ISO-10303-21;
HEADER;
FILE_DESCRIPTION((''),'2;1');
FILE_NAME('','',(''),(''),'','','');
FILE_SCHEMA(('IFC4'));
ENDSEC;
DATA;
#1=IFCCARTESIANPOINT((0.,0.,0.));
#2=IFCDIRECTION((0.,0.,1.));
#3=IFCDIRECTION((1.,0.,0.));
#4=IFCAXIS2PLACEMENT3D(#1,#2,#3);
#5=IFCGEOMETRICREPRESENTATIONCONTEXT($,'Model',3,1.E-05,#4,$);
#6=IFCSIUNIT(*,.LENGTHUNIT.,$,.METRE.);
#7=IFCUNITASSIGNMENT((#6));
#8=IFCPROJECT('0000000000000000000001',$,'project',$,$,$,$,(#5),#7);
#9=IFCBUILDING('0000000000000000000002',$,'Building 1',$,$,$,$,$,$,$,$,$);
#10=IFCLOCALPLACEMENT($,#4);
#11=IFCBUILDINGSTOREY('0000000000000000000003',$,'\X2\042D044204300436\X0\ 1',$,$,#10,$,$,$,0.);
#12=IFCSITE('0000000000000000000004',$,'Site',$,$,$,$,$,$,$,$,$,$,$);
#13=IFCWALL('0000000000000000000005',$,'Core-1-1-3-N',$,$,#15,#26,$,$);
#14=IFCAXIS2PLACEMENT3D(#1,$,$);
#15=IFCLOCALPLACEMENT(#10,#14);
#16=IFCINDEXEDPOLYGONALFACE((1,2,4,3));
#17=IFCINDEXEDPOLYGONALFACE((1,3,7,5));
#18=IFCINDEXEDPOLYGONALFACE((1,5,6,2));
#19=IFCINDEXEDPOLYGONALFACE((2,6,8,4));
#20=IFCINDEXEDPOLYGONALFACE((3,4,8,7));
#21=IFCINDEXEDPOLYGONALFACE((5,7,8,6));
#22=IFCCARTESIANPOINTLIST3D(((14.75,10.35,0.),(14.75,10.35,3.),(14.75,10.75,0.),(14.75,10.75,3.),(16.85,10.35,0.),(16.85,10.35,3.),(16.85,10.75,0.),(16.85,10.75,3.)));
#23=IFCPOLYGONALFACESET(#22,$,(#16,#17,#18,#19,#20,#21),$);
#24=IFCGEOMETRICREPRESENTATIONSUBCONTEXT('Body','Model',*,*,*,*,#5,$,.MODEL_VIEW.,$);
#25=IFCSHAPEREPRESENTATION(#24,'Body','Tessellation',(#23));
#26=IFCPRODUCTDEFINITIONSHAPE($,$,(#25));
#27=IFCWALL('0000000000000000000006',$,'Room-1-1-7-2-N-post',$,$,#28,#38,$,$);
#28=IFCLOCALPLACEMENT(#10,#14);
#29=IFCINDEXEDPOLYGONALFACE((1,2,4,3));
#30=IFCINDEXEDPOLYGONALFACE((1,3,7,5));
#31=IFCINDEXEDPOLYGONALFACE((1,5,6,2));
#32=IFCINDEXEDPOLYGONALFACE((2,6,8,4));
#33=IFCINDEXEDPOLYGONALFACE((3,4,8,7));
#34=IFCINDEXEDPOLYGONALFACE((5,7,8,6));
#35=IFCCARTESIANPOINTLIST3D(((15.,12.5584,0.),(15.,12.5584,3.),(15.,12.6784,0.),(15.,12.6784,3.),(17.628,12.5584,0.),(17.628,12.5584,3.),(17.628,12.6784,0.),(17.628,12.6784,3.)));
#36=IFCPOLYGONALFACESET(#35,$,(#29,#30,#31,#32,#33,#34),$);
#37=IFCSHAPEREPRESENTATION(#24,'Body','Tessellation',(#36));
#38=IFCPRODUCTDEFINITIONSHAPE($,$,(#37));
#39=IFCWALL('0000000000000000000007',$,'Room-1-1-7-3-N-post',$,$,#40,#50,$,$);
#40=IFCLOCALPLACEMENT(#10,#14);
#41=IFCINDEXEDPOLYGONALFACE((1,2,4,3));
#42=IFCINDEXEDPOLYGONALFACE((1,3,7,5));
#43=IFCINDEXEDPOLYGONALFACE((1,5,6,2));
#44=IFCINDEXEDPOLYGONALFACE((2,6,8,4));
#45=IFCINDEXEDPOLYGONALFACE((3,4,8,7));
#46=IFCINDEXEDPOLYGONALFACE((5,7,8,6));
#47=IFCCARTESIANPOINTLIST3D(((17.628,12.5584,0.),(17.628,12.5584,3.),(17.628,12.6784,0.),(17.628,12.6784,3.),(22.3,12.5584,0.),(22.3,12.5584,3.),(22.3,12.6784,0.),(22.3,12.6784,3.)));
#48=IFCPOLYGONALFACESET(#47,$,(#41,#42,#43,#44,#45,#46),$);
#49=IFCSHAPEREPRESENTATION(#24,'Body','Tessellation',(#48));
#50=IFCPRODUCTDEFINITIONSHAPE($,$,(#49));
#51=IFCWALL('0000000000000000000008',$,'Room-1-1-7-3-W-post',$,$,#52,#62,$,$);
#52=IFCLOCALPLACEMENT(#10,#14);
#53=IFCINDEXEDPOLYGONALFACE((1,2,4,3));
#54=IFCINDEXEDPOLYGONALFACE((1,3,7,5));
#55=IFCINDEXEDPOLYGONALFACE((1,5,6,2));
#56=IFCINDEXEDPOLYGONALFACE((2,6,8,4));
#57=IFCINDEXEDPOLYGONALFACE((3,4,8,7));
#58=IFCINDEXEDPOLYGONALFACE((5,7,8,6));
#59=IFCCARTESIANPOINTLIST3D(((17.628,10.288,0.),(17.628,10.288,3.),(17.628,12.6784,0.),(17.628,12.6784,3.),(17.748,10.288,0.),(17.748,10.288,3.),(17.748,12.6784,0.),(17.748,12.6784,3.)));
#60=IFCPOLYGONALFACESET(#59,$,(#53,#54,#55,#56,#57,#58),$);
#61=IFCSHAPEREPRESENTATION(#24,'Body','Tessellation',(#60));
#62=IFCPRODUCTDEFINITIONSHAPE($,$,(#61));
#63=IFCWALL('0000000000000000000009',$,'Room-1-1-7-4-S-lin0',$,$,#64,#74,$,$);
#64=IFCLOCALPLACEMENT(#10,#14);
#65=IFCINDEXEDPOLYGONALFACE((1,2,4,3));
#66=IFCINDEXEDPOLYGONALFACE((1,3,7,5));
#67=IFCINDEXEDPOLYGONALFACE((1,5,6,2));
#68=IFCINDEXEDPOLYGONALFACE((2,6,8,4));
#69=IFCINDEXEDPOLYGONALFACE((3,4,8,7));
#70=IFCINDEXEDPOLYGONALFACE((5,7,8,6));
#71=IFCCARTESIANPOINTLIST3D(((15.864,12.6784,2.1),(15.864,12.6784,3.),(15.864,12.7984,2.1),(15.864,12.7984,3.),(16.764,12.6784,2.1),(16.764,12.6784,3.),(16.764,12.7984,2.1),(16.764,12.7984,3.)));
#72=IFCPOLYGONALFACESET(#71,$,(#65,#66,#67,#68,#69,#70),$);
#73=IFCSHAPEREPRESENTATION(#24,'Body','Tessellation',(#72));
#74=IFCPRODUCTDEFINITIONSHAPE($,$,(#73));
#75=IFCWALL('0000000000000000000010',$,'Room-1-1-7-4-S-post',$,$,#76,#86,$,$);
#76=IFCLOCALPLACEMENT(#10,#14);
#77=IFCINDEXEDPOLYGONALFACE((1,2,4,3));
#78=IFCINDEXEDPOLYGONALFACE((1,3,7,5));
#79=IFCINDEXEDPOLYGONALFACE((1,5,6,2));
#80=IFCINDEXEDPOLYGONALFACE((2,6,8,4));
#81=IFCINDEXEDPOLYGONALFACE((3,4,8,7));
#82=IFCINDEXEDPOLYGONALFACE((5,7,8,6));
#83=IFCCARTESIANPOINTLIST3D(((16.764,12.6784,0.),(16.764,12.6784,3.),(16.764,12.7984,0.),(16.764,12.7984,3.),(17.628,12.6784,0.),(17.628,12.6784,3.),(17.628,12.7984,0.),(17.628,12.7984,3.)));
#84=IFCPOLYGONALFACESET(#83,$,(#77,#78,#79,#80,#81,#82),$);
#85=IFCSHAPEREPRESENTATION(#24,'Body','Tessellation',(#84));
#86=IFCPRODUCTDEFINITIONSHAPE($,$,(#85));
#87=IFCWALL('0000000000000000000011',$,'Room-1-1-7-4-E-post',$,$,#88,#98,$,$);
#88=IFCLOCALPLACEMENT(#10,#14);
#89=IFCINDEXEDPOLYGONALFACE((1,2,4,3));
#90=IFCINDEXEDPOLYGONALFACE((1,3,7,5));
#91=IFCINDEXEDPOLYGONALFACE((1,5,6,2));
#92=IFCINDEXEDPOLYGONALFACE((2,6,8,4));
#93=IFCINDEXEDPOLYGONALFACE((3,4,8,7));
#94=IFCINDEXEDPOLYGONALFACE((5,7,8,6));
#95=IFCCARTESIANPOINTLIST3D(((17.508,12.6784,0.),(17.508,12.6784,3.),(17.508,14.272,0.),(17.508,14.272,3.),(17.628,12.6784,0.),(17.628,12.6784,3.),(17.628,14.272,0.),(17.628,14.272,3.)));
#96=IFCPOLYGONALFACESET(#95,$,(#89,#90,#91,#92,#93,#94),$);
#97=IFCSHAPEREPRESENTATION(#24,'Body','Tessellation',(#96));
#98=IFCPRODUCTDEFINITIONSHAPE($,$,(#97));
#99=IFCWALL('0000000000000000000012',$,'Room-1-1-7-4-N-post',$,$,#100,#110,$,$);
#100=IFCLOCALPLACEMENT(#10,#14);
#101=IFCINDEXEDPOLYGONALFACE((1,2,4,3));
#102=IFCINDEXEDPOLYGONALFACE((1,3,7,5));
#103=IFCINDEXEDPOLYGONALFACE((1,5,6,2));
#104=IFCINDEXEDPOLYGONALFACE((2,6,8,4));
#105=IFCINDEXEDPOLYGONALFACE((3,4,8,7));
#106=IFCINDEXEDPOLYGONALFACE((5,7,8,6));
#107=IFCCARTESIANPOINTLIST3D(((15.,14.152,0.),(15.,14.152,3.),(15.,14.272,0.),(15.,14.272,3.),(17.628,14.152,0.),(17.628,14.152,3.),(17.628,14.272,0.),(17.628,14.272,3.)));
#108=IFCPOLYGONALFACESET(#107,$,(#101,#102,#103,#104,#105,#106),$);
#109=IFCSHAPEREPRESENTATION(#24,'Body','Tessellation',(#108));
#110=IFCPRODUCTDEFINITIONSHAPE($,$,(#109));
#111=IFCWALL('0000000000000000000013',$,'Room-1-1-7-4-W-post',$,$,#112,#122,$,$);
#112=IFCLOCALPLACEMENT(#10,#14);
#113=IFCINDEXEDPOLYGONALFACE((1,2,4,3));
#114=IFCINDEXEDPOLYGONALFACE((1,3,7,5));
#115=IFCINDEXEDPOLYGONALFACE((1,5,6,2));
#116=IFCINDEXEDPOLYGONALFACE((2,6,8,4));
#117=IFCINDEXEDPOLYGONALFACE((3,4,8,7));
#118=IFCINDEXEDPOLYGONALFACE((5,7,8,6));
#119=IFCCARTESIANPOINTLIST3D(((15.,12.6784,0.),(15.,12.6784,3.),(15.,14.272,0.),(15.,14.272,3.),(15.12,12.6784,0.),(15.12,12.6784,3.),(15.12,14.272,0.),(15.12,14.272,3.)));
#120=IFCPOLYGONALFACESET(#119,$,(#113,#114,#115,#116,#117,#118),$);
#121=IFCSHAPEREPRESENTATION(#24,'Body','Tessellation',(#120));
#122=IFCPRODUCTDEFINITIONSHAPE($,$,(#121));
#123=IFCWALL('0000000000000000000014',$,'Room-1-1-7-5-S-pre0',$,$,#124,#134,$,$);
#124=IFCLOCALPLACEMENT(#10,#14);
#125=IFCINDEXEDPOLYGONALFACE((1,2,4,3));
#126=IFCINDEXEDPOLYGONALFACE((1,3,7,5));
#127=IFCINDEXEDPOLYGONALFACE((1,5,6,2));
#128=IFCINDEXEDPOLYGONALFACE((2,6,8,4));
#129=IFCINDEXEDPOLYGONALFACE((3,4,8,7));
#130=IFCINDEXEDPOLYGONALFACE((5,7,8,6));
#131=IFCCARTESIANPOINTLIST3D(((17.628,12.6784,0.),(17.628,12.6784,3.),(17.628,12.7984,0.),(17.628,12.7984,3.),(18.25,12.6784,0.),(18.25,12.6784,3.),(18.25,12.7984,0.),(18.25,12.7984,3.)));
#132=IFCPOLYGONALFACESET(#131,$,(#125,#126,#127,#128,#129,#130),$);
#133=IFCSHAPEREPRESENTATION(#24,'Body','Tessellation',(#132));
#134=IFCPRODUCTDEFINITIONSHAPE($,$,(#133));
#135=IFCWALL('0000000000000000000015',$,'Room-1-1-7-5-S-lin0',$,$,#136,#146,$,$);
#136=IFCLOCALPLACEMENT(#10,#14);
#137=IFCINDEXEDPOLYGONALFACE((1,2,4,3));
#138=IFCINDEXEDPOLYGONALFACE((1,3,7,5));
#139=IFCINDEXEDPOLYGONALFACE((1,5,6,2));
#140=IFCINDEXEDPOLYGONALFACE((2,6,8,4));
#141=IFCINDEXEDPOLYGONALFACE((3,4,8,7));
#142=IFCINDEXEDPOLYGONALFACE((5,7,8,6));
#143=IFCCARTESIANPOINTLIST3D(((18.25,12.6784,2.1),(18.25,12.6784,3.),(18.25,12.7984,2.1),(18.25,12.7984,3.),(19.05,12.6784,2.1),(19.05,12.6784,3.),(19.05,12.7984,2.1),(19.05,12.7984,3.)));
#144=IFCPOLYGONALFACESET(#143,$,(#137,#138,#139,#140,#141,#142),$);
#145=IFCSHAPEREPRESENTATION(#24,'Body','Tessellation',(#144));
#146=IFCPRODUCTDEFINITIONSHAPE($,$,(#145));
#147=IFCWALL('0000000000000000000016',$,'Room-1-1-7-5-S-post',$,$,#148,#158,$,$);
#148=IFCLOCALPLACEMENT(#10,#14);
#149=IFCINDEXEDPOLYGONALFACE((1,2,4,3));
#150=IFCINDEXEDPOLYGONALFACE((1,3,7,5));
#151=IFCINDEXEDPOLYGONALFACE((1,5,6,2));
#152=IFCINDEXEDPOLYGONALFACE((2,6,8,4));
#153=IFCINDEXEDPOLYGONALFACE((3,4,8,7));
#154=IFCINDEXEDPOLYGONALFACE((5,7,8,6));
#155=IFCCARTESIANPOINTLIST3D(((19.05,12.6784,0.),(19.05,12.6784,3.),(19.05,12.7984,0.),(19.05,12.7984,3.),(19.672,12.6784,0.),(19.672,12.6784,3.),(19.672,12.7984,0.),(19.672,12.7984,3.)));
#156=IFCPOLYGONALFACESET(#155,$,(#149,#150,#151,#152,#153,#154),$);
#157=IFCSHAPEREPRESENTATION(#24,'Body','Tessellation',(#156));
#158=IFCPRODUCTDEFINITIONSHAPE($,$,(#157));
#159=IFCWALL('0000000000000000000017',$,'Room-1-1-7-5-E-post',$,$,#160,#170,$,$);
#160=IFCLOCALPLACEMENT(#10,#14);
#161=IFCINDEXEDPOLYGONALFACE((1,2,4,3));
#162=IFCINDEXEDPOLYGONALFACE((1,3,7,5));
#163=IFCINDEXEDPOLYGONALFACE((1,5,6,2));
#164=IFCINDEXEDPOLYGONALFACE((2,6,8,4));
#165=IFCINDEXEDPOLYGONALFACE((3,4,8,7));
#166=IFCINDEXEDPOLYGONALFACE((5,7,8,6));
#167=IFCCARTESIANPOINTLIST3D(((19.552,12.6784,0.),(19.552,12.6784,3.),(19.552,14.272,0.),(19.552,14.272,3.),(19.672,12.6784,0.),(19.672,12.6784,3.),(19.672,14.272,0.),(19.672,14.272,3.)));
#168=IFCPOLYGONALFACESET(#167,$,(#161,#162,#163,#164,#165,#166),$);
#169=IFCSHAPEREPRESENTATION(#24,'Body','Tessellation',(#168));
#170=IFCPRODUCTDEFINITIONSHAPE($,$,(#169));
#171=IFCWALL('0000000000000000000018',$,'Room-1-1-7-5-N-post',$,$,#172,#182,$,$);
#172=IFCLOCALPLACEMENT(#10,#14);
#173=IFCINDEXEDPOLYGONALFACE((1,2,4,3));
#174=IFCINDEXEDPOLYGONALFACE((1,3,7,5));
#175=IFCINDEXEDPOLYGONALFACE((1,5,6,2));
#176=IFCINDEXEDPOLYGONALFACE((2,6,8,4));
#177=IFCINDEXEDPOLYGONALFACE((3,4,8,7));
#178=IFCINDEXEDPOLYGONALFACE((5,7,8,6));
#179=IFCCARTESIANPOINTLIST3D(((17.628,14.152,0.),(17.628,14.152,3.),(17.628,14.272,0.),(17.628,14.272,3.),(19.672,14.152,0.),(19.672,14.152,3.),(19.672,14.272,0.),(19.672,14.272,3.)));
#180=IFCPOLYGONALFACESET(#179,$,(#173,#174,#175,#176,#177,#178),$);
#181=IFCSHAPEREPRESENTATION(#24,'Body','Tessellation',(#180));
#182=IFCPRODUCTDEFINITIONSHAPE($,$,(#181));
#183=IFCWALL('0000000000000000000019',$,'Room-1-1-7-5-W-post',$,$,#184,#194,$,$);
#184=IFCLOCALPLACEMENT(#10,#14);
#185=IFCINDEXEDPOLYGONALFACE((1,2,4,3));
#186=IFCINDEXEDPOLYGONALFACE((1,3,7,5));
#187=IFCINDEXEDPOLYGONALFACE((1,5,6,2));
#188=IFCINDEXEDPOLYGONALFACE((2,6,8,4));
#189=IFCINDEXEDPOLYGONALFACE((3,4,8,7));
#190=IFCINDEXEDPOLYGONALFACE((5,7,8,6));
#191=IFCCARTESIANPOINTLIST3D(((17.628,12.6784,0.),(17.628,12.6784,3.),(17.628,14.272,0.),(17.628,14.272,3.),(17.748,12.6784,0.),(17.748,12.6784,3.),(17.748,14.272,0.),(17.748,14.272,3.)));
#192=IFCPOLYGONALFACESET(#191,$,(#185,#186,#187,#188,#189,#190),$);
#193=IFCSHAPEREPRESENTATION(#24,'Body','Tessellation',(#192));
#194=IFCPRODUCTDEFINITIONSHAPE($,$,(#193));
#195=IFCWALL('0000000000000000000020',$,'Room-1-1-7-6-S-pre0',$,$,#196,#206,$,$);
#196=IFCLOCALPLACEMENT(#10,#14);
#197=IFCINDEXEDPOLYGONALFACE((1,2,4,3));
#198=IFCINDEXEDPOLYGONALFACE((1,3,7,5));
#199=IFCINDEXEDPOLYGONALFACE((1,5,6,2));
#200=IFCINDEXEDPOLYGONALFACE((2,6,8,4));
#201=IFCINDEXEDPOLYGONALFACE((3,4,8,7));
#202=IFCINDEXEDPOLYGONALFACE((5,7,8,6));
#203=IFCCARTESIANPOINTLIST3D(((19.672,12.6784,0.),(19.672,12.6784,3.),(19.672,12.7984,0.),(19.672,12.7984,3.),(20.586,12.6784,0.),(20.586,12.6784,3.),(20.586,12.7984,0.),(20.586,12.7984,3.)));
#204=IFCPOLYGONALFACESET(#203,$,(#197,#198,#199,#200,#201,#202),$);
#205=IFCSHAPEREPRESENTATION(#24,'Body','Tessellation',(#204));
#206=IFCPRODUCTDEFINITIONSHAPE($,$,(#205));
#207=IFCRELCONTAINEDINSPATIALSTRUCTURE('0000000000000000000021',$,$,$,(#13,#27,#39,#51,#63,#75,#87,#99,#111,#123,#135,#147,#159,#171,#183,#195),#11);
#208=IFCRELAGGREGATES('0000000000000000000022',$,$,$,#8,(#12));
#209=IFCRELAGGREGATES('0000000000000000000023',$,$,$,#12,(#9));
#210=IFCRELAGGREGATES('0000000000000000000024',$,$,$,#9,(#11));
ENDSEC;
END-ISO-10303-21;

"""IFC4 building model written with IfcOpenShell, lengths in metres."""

from ifc_helpers import new_model, si_unit, frame, origin_with_axes, place, context, subcontext, project, spatial, indexed_curve, outline, extrude, element, save


model = new_model("IFC4")

# Units and contexts
model_context = context("Model", 3, precision=1e-05, world=origin_with_axes())
body_context = subcontext(model_context, "Body", "Model", "MODEL_VIEW")
ifc_project = project(units=[si_unit("LENGTHUNIT", "METRE")], contexts=[model_context])

# Site, building, storey
site = spatial("IfcSite", under=ifc_project, Name="Site")
building = spatial("IfcBuilding", under=site, Name="Building 1")
storey_placement = place(None, origin_with_axes())
storey = spatial("IfcBuildingStorey", under=building, at=storey_placement, Name="Этаж 1", Elevation=0.0)

# Walls
wall_1_placement = place(storey_placement, frame((16.85, 10.75, 0.0), z_axis=(0.0, 0.0, 1.0), x_axis=(-1.0, 0.0, 0.0)))
element("IfcWall", 1, at=wall_1_placement, inside=storey, Name="Core-1-1-3-N", context=body_context, shape_type="SweptSolid", body=[
    extrude(outline(indexed_curve([(0.0, 0.0), (0.0, 0.4), (2.1, 0.4), (2.1, 0.0), (0.0, 0.0)], self_intersect=False)), origin_with_axes(), (0.0, 0.0, 1.0), 3.0),
])
wall_2_placement = place(storey_placement, frame((17.628, 12.6784, 0.0), z_axis=(0.0, 0.0, 1.0), x_axis=(-1.0, 0.0, 0.0)))
element("IfcWall", 2, at=wall_2_placement, inside=storey, Name="Room-1-1-7-2-N-post", context=body_context, shape_type="SweptSolid", body=[
    extrude(outline(indexed_curve([(0.0, 0.0), (0.0, 0.12), (2.628, 0.12), (2.628, 0.0), (0.0, 0.0)], self_intersect=False)), origin_with_axes(), (0.0, 0.0, 1.0), 3.0),
])
wall_3_placement = place(storey_placement, frame((22.3, 12.6784, 0.0), z_axis=(0.0, 0.0, 1.0), x_axis=(-1.0, 0.0, 0.0)))
element("IfcWall", 3, at=wall_3_placement, inside=storey, Name="Room-1-1-7-3-N-post", context=body_context, shape_type="SweptSolid", body=[
    extrude(outline(indexed_curve([(0.0, 0.0), (0.0, 0.12), (4.672, 0.12), (4.672, 0.0), (0.0, 0.0)], self_intersect=False)), origin_with_axes(), (0.0, 0.0, 1.0), 3.0),
])
wall_4_placement = place(storey_placement, frame((17.628, 12.6784, 0.0), z_axis=(0.0, 0.0, 1.0), x_axis=(0.0, -1.0, 0.0)))
element("IfcWall", 4, at=wall_4_placement, inside=storey, Name="Room-1-1-7-3-W-post", context=body_context, shape_type="SweptSolid", body=[
    extrude(outline(indexed_curve([(0.0, 0.0), (0.0, 0.12), (2.3904, 0.12), (2.3904, 0.0), (0.0, 0.0)], self_intersect=False)), origin_with_axes(), (0.0, 0.0, 1.0), 3.0),
])
wall_5_placement = place(storey_placement, frame((15.864, 12.6784, 2.1), z_axis=(0.0, 0.0, 1.0), x_axis=(1.0, 0.0, 0.0)))
element("IfcWall", 5, at=wall_5_placement, inside=storey, Name="Room-1-1-7-4-S-lin0", context=body_context, shape_type="SweptSolid", body=[
    extrude(outline(indexed_curve([(0.0, 0.0), (0.0, 0.12), (0.9, 0.12), (0.9, 0.0), (0.0, 0.0)], self_intersect=False)), origin_with_axes(), (0.0, 0.0, 1.0), 0.9),
])
wall_6_placement = place(storey_placement, frame((16.764, 12.6784, 0.0), z_axis=(0.0, 0.0, 1.0), x_axis=(1.0, 0.0, 0.0)))
element("IfcWall", 6, at=wall_6_placement, inside=storey, Name="Room-1-1-7-4-S-post", context=body_context, shape_type="SweptSolid", body=[
    extrude(outline(indexed_curve([(0.0, 0.0), (0.0, 0.12), (0.864, 0.12), (0.864, 0.0), (0.0, 0.0)], self_intersect=False)), origin_with_axes(), (0.0, 0.0, 1.0), 3.0),
])
wall_7_placement = place(storey_placement, frame((17.628, 12.6784, 0.0), z_axis=(0.0, 0.0, 1.0), x_axis=(0.0, 1.0, 0.0)))
element("IfcWall", 7, at=wall_7_placement, inside=storey, Name="Room-1-1-7-4-E-post", context=body_context, shape_type="SweptSolid", body=[
    extrude(outline(indexed_curve([(0.0, 0.0), (0.0, 0.12), (1.5936, 0.12), (1.5936, 0.0), (0.0, 0.0)], self_intersect=False)), origin_with_axes(), (0.0, 0.0, 1.0), 3.0),
])
wall_8_placement = place(storey_placement, frame((17.628, 14.272, 0.0), z_axis=(0.0, 0.0, 1.0), x_axis=(-1.0, 0.0, 0.0)))
element("IfcWall", 8, at=wall_8_placement, inside=storey, Name="Room-1-1-7-4-N-post", context=body_context, shape_type="SweptSolid", body=[
    extrude(outline(indexed_curve([(0.0, 0.0), (0.0, 0.12), (2.628, 0.12), (2.628, 0.0), (0.0, 0.0)], self_intersect=False)), origin_with_axes(), (0.0, 0.0, 1.0), 3.0),
])
wall_9_placement = place(storey_placement, frame((15.0, 14.272, 0.0), z_axis=(0.0, 0.0, 1.0), x_axis=(0.0, -1.0, 0.0)))
element("IfcWall", 9, at=wall_9_placement, inside=storey, Name="Room-1-1-7-4-W-post", context=body_context, shape_type="SweptSolid", body=[
    extrude(outline(indexed_curve([(0.0, 0.0), (0.0, 0.12), (1.5936, 0.12), (1.5936, 0.0), (0.0, 0.0)], self_intersect=False)), origin_with_axes(), (0.0, 0.0, 1.0), 3.0),
])
wall_10_placement = place(storey_placement, frame((17.628, 12.6784, 0.0), z_axis=(0.0, 0.0, 1.0), x_axis=(1.0, 0.0, 0.0)))
element("IfcWall", 10, at=wall_10_placement, inside=storey, Name="Room-1-1-7-5-S-pre0", context=body_context, shape_type="SweptSolid", body=[
    extrude(outline(indexed_curve([(0.0, 0.0), (0.0, 0.12), (0.622, 0.12), (0.622, 0.0), (0.0, 0.0)], self_intersect=False)), origin_with_axes(), (0.0, 0.0, 1.0), 3.0),
])
wall_11_placement = place(storey_placement, frame((18.25, 12.6784, 2.1), z_axis=(0.0, 0.0, 1.0), x_axis=(1.0, 0.0, 0.0)))
element("IfcWall", 11, at=wall_11_placement, inside=storey, Name="Room-1-1-7-5-S-lin0", context=body_context, shape_type="SweptSolid", body=[
    extrude(outline(indexed_curve([(0.0, 0.0), (0.0, 0.12), (0.8, 0.12), (0.8, 0.0), (0.0, 0.0)], self_intersect=False)), origin_with_axes(), (0.0, 0.0, 1.0), 0.9),
])
wall_12_placement = place(storey_placement, frame((19.05, 12.6784, 0.0), z_axis=(0.0, 0.0, 1.0), x_axis=(1.0, 0.0, 0.0)))
element("IfcWall", 12, at=wall_12_placement, inside=storey, Name="Room-1-1-7-5-S-post", context=body_context, shape_type="SweptSolid", body=[
    extrude(outline(indexed_curve([(0.0, 0.0), (0.0, 0.12), (0.622, 0.12), (0.622, 0.0), (0.0, 0.0)], self_intersect=False)), origin_with_axes(), (0.0, 0.0, 1.0), 3.0),
])
wall_13_placement = place(storey_placement, frame((19.672, 12.6784, 0.0), z_axis=(0.0, 0.0, 1.0), x_axis=(0.0, 1.0, 0.0)))
element("IfcWall", 13, at=wall_13_placement, inside=storey, Name="Room-1-1-7-5-E-post", context=body_context, shape_type="SweptSolid", body=[
    extrude(outline(indexed_curve([(0.0, 0.0), (0.0, 0.12), (1.5936, 0.12), (1.5936, 0.0), (0.0, 0.0)], self_intersect=False)), origin_with_axes(), (0.0, 0.0, 1.0), 3.0),
])
wall_14_placement = place(storey_placement, frame((19.672, 14.272, 0.0), z_axis=(0.0, 0.0, 1.0), x_axis=(-1.0, 0.0, 0.0)))
element("IfcWall", 14, at=wall_14_placement, inside=storey, Name="Room-1-1-7-5-N-post", context=body_context, shape_type="SweptSolid", body=[
    extrude(outline(indexed_curve([(0.0, 0.0), (0.0, 0.12), (2.044, 0.12), (2.044, 0.0), (0.0, 0.0)], self_intersect=False)), origin_with_axes(), (0.0, 0.0, 1.0), 3.0),
])
wall_15_placement = place(storey_placement, frame((17.628, 14.272, 0.0), z_axis=(0.0, 0.0, 1.0), x_axis=(0.0, -1.0, 0.0)))
element("IfcWall", 15, at=wall_15_placement, inside=storey, Name="Room-1-1-7-5-W-post", context=body_context, shape_type="SweptSolid", body=[
    extrude(outline(indexed_curve([(0.0, 0.0), (0.0, 0.12), (1.5936, 0.12), (1.5936, 0.0), (0.0, 0.0)], self_intersect=False)), origin_with_axes(), (0.0, 0.0, 1.0), 3.0),
])
wall_16_placement = place(storey_placement, frame((19.672, 12.6784, 0.0), z_axis=(0.0, 0.0, 1.0), x_axis=(1.0, 0.0, 0.0)))
element("IfcWall", 16, at=wall_16_placement, inside=storey, Name="Room-1-1-7-6-S-pre0", context=body_context, shape_type="SweptSolid", body=[
    extrude(outline(indexed_curve([(0.0, 0.0), (0.0, 0.12), (0.914, 0.12), (0.914, 0.0), (0.0, 0.0)], self_intersect=False)), origin_with_axes(), (0.0, 0.0, 1.0), 3.0),
])

save(model, "model.ifc")
